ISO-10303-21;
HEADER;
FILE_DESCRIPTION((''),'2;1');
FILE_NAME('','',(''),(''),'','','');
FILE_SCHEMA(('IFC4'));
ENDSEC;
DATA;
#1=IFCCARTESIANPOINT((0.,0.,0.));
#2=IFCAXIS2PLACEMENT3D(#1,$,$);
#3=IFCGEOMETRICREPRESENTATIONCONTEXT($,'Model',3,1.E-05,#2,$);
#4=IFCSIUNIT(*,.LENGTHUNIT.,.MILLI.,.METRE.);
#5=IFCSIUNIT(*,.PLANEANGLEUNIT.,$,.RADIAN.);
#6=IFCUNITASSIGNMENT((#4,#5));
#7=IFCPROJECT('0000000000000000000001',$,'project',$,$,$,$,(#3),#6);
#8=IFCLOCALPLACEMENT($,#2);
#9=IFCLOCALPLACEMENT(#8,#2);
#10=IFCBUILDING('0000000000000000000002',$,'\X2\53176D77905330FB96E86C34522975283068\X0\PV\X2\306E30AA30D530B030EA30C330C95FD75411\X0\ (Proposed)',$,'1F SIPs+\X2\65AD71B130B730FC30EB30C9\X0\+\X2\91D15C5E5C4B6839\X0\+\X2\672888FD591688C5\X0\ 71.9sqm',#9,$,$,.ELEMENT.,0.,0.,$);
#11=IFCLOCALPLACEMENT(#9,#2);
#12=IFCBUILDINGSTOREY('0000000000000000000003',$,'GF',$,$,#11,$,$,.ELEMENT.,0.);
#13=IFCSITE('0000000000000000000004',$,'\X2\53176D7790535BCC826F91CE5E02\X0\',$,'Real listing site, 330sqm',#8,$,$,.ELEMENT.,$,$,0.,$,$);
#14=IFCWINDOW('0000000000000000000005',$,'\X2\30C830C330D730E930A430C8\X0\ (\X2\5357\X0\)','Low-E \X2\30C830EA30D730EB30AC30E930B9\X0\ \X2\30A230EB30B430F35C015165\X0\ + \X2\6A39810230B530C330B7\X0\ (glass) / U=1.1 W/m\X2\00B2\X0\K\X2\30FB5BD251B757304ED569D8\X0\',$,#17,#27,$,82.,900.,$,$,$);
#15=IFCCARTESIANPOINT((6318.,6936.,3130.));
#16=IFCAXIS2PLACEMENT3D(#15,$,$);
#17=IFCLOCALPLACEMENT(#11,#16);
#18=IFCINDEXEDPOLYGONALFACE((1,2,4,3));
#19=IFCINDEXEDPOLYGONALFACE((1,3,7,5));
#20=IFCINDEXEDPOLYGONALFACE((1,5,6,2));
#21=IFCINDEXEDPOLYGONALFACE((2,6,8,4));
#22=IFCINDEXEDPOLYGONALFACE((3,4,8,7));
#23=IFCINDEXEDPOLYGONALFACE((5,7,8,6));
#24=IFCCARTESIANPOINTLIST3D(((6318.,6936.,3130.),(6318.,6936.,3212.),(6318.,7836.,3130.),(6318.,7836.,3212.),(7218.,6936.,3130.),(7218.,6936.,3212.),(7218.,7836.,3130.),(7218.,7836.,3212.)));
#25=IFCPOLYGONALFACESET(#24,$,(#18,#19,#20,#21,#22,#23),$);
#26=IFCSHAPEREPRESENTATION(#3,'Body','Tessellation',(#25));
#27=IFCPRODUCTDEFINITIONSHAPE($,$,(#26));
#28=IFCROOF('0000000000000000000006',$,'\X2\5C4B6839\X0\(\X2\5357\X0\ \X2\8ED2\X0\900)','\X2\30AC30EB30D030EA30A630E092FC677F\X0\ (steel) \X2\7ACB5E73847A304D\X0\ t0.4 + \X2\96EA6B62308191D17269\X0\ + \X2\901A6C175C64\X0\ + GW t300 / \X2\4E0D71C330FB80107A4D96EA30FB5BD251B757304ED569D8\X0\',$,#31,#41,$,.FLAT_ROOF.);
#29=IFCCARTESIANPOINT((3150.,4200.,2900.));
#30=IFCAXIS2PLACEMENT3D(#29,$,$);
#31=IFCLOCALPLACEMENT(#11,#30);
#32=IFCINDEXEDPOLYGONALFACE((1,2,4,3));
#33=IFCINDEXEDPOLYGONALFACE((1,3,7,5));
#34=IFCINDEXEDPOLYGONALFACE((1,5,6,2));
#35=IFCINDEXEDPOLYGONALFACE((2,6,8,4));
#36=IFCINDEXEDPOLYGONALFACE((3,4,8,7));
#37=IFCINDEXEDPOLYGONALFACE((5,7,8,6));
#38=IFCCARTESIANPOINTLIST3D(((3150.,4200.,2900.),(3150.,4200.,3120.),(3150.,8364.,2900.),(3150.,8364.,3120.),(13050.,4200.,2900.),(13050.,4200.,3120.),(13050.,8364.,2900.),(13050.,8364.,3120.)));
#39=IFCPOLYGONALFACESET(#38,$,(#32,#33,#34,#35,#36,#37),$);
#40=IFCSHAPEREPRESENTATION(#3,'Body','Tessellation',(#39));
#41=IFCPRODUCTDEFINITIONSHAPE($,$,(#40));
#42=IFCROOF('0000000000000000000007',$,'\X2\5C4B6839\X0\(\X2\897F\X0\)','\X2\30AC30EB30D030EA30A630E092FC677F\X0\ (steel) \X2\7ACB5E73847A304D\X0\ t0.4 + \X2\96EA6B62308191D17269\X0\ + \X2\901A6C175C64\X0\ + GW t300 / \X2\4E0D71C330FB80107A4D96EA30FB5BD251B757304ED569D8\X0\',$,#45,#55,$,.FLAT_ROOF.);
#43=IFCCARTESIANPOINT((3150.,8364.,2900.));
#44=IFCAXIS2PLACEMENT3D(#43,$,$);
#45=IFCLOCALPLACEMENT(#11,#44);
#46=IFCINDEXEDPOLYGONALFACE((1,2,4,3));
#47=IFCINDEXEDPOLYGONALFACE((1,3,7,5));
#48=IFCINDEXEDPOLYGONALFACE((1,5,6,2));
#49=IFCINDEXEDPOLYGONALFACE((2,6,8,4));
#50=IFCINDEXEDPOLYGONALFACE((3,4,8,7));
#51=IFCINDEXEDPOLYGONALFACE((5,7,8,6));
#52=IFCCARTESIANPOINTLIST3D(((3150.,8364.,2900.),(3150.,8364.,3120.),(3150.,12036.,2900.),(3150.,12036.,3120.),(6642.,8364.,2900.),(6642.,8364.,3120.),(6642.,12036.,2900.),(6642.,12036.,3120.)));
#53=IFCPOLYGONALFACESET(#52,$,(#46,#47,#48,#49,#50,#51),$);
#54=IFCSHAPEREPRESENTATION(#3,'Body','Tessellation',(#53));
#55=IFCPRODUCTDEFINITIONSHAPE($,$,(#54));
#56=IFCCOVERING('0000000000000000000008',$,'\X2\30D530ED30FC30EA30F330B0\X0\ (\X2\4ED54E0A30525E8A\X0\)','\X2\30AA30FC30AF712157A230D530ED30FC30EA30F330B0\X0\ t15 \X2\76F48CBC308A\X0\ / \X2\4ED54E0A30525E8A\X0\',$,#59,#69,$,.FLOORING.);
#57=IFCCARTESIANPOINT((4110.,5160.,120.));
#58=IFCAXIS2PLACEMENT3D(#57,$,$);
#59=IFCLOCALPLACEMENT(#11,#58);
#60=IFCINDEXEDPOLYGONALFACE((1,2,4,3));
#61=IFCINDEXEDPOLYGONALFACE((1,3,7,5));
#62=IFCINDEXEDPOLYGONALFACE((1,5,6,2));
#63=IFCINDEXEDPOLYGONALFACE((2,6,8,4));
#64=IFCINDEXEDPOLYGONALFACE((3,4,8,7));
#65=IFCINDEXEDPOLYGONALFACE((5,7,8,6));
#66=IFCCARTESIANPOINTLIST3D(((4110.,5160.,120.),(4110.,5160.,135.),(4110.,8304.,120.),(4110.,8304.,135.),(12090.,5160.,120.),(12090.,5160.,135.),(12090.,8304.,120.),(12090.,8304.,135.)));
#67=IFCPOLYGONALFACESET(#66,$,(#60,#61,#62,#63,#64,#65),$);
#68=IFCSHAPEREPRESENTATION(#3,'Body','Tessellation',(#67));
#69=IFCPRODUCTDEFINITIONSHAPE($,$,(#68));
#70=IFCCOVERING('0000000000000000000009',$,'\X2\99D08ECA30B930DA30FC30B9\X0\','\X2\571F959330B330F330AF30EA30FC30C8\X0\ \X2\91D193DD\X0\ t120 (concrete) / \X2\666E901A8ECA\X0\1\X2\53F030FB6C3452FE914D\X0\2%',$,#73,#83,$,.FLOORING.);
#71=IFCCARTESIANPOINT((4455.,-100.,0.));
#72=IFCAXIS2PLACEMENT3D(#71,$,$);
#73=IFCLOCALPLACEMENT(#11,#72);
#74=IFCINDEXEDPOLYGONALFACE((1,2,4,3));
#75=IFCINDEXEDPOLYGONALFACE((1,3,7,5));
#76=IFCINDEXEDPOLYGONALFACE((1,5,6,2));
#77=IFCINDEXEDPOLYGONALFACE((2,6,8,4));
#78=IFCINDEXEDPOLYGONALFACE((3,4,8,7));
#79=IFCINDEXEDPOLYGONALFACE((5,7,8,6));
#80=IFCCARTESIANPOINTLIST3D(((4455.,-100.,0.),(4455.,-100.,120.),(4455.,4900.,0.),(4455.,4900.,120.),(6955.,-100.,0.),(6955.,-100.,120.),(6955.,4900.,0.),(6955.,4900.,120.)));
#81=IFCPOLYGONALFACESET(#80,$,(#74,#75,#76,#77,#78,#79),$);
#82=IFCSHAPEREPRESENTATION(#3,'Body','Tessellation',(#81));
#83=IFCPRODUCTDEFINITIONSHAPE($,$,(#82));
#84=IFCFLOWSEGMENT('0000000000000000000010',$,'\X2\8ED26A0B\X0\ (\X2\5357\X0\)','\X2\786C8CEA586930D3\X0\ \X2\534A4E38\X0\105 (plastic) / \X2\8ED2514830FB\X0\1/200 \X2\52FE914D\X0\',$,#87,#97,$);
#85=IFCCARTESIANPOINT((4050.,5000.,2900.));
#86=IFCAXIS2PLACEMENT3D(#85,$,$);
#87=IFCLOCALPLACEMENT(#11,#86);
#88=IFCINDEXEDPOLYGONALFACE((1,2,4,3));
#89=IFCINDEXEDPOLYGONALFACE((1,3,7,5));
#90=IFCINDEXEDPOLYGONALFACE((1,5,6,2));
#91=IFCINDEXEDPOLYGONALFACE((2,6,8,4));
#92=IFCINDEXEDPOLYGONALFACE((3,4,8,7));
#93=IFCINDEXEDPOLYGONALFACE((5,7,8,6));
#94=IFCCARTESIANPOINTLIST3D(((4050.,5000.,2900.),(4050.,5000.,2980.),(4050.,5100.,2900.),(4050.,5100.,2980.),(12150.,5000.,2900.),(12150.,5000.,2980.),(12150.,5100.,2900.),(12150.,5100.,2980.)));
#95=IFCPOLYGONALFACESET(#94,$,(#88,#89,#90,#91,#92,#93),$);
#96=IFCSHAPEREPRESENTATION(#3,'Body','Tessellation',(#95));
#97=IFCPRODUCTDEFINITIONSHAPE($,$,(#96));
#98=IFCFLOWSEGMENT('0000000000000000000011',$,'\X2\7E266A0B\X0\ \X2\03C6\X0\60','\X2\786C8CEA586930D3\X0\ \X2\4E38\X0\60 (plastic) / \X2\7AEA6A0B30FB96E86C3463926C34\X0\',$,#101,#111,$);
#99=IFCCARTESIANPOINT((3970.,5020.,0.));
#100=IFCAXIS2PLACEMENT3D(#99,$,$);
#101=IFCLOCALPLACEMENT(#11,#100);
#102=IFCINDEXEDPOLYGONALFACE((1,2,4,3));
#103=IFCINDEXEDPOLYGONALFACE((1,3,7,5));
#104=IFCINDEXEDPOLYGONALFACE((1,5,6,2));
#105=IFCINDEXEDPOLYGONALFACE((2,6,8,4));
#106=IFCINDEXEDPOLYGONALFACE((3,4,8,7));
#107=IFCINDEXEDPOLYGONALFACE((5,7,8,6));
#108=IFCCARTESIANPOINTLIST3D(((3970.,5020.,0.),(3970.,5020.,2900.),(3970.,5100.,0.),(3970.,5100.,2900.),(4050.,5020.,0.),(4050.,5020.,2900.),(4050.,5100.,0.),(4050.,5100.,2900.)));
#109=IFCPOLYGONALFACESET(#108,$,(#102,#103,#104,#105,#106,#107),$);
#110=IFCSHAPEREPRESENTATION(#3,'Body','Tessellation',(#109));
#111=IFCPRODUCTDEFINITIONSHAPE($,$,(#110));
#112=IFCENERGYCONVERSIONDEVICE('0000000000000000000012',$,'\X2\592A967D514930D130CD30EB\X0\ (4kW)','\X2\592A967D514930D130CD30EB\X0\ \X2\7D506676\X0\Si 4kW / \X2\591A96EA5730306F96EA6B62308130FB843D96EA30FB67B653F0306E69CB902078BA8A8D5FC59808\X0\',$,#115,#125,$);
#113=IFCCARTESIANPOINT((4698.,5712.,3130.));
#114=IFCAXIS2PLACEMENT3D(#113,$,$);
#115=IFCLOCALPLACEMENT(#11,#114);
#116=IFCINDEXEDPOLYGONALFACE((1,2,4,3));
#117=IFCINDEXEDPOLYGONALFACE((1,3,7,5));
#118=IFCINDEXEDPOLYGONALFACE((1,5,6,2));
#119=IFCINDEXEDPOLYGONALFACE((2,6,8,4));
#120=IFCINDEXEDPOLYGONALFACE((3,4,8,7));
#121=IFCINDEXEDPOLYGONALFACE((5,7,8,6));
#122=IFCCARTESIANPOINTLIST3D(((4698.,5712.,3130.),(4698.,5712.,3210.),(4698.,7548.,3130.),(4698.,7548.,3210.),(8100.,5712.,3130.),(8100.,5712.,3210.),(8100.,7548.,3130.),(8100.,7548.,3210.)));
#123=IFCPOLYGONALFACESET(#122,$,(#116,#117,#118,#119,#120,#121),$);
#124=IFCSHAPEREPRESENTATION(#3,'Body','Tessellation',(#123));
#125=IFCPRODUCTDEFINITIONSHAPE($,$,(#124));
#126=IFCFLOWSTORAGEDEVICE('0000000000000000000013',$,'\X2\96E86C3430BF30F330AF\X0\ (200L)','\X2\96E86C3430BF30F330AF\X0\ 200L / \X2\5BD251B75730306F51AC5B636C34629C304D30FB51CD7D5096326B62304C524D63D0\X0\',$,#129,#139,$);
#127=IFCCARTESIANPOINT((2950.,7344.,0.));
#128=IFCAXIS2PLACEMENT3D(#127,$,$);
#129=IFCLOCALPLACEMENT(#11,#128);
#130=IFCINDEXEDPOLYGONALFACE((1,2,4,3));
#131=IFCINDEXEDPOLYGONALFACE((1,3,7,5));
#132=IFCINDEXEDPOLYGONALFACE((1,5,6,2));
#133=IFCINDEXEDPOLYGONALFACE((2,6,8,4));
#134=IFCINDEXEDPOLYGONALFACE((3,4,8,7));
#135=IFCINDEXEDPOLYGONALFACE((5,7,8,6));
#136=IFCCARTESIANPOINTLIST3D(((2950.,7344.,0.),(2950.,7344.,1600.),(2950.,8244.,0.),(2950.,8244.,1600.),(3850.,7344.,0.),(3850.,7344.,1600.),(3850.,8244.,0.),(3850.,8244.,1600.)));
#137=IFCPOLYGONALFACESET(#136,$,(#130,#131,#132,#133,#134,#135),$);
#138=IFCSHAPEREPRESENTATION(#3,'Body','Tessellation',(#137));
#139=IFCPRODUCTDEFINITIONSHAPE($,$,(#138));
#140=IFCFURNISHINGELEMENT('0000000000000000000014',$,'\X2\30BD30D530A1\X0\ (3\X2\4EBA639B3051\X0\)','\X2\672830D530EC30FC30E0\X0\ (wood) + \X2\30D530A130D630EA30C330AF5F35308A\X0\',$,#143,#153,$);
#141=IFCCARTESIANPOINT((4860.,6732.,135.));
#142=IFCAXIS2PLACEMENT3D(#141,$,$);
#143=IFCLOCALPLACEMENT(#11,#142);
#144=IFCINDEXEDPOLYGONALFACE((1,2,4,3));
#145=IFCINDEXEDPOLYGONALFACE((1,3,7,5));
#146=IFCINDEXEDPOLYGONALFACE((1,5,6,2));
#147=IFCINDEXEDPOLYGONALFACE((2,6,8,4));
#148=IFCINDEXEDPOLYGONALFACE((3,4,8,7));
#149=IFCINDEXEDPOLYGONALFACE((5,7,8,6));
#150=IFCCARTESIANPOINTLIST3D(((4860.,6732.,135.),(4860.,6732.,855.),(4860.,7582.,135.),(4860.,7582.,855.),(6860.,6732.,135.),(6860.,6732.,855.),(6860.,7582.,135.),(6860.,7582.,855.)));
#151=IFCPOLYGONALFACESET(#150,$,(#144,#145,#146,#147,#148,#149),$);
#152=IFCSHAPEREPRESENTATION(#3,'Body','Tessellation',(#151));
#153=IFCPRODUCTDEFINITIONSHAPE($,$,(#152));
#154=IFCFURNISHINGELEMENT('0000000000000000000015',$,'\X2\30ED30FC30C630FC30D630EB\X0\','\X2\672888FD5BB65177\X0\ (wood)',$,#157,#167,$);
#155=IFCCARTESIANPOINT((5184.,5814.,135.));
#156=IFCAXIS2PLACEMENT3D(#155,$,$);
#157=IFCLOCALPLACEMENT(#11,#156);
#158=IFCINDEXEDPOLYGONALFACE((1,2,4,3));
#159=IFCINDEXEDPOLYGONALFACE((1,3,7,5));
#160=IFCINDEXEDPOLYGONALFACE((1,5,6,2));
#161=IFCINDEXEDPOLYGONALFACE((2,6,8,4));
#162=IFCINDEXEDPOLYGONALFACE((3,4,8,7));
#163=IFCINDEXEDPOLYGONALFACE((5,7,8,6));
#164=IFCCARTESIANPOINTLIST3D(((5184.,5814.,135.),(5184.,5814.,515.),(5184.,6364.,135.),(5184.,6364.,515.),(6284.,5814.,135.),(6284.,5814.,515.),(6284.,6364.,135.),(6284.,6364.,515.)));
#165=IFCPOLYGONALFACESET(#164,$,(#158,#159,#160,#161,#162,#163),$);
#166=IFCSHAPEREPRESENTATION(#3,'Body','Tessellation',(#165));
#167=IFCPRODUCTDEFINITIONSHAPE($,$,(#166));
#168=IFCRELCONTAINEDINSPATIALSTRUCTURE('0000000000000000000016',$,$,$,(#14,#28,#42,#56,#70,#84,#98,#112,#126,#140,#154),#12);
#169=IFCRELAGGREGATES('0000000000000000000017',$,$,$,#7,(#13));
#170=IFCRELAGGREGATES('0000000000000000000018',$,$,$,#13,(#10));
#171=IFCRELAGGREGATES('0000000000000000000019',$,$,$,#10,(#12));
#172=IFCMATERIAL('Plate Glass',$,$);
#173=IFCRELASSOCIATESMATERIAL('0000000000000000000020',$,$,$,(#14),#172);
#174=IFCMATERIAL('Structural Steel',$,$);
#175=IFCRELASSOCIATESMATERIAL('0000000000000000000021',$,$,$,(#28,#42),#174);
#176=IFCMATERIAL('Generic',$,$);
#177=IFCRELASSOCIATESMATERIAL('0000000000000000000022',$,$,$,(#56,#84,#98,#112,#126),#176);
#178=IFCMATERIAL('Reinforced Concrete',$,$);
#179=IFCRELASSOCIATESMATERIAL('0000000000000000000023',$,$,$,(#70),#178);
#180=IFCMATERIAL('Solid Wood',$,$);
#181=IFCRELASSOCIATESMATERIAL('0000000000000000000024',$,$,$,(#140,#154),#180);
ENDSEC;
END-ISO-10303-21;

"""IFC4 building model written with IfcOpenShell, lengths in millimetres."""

from ifc_helpers import new_model, si_unit, frame, frame_2d, origin, place, context, project, spatial, rectangle, extrude, material, element, save


model = new_model("IFC4")

# Units and contexts
model_context = context("Model", 3, precision=1e-05, world=origin())
ifc_project = project(units=[si_unit("LENGTHUNIT", "METRE", prefix="MILLI"), si_unit("PLANEANGLEUNIT", "RADIAN")], contexts=[model_context])

# Site, building, storey
site_placement = place(None, origin())
site = spatial("IfcSite", under=ifc_project, at=site_placement, Name="北海道富良野市", ObjectType="Real listing site, 330sqm", CompositionType="ELEMENT", RefElevation=0.0)
building_placement = place(site_placement, origin())
building = spatial("IfcBuilding", under=site, at=building_placement, Name="北海道・雨水利用とPVのオフグリッド志向 (Proposed)", ObjectType="1F SIPs+断熱シールド+金属屋根+木製外装 71.9sqm", CompositionType="ELEMENT", ElevationOfRefHeight=0.0, ElevationOfTerrain=0.0)
storey_placement = place(building_placement, origin())
storey = spatial("IfcBuildingStorey", under=building, at=storey_placement, Name="GF", CompositionType="ELEMENT", Elevation=0.0)

# Shared definitions
ifc_material_1 = material(Name="Solid Wood")

# Shared definitions
ifc_material_2 = material(Name="Reinforced Concrete")

# Shared definitions
ifc_material_3 = material(Name="Plate Glass")

# Window
window_1_placement = place(storey_placement, frame((6318.0, 6936.0, 3130.0)))
element("IfcWindow", 1, at=window_1_placement, inside=storey, material=ifc_material_3, Name="トップライト (南)", Description="Low-E トリプルガラス アルゴン封入 + 樹脂サッシ (glass) / U=1.1 W/m²K・寒冷地仕様", OverallHeight=82.0, OverallWidth=900.0, context=model_context, shape_type="SweptSolid", body=[
    extrude(rectangle(XDim=900.0, YDim=900.0, at=frame_2d((450.0, 450.0))), frame((6318.0, 6936.0, 3130.0)), (0.0, 0.0, 1.0), 82.0),
])

# Roofs
ifc_material_4 = material(Name="Structural Steel")
roof_1_placement = place(storey_placement, frame((3150.0, 4200.0, 2900.0)))
element("IfcRoof", 2, at=roof_1_placement, inside=storey, material=ifc_material_4, Name="屋根(南 軒900)", Description="ガルバリウム鋼板 (steel) 立平葺き t0.4 + 雪止め金物 + 通気層 + GW t300 / 不燃・耐積雪・寒冷地仕様", PredefinedType="FLAT_ROOF", context=model_context, shape_type="SweptSolid", body=[
    extrude(rectangle(XDim=9900.0, YDim=4164.0, at=frame_2d((4950.0, 2082.0))), frame((3150.0, 4200.0, 2900.0)), (0.0, 0.0, 1.0), 220.0),
])
roof_2_placement = place(storey_placement, frame((3150.0, 8364.0, 2900.0)))
element("IfcRoof", 3, at=roof_2_placement, inside=storey, material=ifc_material_4, Name="屋根(西)", Description="ガルバリウム鋼板 (steel) 立平葺き t0.4 + 雪止め金物 + 通気層 + GW t300 / 不燃・耐積雪・寒冷地仕様", PredefinedType="FLAT_ROOF", context=model_context, shape_type="SweptSolid", body=[
    extrude(rectangle(XDim=3492.0, YDim=3672.0, at=frame_2d((1746.0, 1836.0))), frame((3150.0, 8364.0, 2900.0)), (0.0, 0.0, 1.0), 220.0),
])

# Coverings
ifc_material_5 = material(Name="Generic")
covering_1_placement = place(storey_placement, frame((4110.0, 5160.0, 120.0)))
element("IfcCovering", 4, at=covering_1_placement, inside=storey, material=ifc_material_5, Name="フローリング (仕上げ床)", Description="オーク無垢フローリング t15 直貼り / 仕上げ床", PredefinedType="FLOORING", context=model_context, shape_type="SweptSolid", body=[
    extrude(rectangle(XDim=7980.0, YDim=3144.0, at=frame_2d((3990.0, 1572.0))), frame((4110.0, 5160.0, 120.0)), (0.0, 0.0, 1.0), 15.0),
])
covering_2_placement = place(storey_placement, frame((4455.0, -100.0, 0.0)))
element("IfcCovering", 5, at=covering_2_placement, inside=storey, material=ifc_material_2, Name="駐車スペース", Description="土間コンクリート 金鏝 t120 (concrete) / 普通車1台・水勾配2%", PredefinedType="FLOORING", context=model_context, shape_type="SweptSolid", body=[
    extrude(rectangle(XDim=2500.0, YDim=5000.0, at=frame_2d((1250.0, 2500.0))), frame((4455.0, -100.0, 0.0)), (0.0, 0.0, 1.0), 120.0),
])

# Flow segments
flow_segment_1_placement = place(storey_placement, frame((4050.0, 5000.0, 2900.0)))
element("IfcFlowSegment", 6, at=flow_segment_1_placement, inside=storey, material=ifc_material_5, Name="軒樋 (南)", Description="硬質塩ビ 半丸105 (plastic) / 軒先・1/200 勾配", context=model_context, shape_type="SweptSolid", body=[
    extrude(rectangle(XDim=8100.0, YDim=100.0, at=frame_2d((4050.0, 50.0))), frame((4050.0, 5000.0, 2900.0)), (0.0, 0.0, 1.0), 80.0),
])
flow_segment_2_placement = place(storey_placement, frame((3970.0, 5020.0, 0.0)))
element("IfcFlowSegment", 7, at=flow_segment_2_placement, inside=storey, material=ifc_material_5, Name="縦樋 φ60", Description="硬質塩ビ 丸60 (plastic) / 竪樋・雨水排水", context=model_context, shape_type="SweptSolid", body=[
    extrude(rectangle(XDim=80.0, YDim=80.0, at=frame_2d((40.0, 40.0))), frame((3970.0, 5020.0, 0.0)), (0.0, 0.0, 1.0), 2900.0),
])

# Energy conversion device
energy_conversion_device_placement = place(storey_placement, frame((4698.0, 5712.0, 3130.0)))
element("IfcEnergyConversionDevice", 8, at=energy_conversion_device_placement, inside=storey, material=ifc_material_5, Name="太陽光パネル (4kW)", Description="太陽光パネル 結晶Si 4kW / 多雪地は雪止め・落雪・架台の構造確認必須", context=model_context, shape_type="SweptSolid", body=[
    extrude(rectangle(XDim=3402.0, YDim=1836.0, at=frame_2d((1701.0, 918.0))), frame((4698.0, 5712.0, 3130.0)), (0.0, 0.0, 1.0), 80.0),
])

# Flow storage device
flow_storage_device_placement = place(storey_placement, frame((2950.0, 7344.0, 0.0)))
element("IfcFlowStorageDevice", 9, at=flow_storage_device_placement, inside=storey, material=ifc_material_5, Name="雨水タンク (200L)", Description="雨水タンク 200L / 寒冷地は冬季水抜き・凍結防止が前提", context=model_context, shape_type="SweptSolid", body=[
    extrude(rectangle(XDim=900.0, YDim=900.0, at=frame_2d((450.0, 450.0))), frame((2950.0, 7344.0, 0.0)), (0.0, 0.0, 1.0), 1600.0),
])

# Furnishing elements
furnishing_1_placement = place(storey_placement, frame((4860.0, 6732.0, 135.0)))
element("IfcFurnishingElement", 10, at=furnishing_1_placement, inside=storey, material=ifc_material_1, Name="ソファ (3人掛け)", Description="木フレーム (wood) + ファブリック張り", context=model_context, shape_type="SweptSolid", body=[
    extrude(rectangle(XDim=2000.0, YDim=850.0, at=frame_2d((1000.0, 425.0))), frame((4860.0, 6732.0, 135.0)), (0.0, 0.0, 1.0), 720.0),
])
furnishing_2_placement = place(storey_placement, frame((5184.0, 5814.0, 135.0)))
element("IfcFurnishingElement", 11, at=furnishing_2_placement, inside=storey, material=ifc_material_1, Name="ローテーブル", Description="木製家具 (wood)", context=model_context, shape_type="SweptSolid", body=[
    extrude(rectangle(XDim=1100.0, YDim=550.0, at=frame_2d((550.0, 275.0))), frame((5184.0, 5814.0, 135.0)), (0.0, 0.0, 1.0), 380.0),
])

save(model, "model.ifc")
